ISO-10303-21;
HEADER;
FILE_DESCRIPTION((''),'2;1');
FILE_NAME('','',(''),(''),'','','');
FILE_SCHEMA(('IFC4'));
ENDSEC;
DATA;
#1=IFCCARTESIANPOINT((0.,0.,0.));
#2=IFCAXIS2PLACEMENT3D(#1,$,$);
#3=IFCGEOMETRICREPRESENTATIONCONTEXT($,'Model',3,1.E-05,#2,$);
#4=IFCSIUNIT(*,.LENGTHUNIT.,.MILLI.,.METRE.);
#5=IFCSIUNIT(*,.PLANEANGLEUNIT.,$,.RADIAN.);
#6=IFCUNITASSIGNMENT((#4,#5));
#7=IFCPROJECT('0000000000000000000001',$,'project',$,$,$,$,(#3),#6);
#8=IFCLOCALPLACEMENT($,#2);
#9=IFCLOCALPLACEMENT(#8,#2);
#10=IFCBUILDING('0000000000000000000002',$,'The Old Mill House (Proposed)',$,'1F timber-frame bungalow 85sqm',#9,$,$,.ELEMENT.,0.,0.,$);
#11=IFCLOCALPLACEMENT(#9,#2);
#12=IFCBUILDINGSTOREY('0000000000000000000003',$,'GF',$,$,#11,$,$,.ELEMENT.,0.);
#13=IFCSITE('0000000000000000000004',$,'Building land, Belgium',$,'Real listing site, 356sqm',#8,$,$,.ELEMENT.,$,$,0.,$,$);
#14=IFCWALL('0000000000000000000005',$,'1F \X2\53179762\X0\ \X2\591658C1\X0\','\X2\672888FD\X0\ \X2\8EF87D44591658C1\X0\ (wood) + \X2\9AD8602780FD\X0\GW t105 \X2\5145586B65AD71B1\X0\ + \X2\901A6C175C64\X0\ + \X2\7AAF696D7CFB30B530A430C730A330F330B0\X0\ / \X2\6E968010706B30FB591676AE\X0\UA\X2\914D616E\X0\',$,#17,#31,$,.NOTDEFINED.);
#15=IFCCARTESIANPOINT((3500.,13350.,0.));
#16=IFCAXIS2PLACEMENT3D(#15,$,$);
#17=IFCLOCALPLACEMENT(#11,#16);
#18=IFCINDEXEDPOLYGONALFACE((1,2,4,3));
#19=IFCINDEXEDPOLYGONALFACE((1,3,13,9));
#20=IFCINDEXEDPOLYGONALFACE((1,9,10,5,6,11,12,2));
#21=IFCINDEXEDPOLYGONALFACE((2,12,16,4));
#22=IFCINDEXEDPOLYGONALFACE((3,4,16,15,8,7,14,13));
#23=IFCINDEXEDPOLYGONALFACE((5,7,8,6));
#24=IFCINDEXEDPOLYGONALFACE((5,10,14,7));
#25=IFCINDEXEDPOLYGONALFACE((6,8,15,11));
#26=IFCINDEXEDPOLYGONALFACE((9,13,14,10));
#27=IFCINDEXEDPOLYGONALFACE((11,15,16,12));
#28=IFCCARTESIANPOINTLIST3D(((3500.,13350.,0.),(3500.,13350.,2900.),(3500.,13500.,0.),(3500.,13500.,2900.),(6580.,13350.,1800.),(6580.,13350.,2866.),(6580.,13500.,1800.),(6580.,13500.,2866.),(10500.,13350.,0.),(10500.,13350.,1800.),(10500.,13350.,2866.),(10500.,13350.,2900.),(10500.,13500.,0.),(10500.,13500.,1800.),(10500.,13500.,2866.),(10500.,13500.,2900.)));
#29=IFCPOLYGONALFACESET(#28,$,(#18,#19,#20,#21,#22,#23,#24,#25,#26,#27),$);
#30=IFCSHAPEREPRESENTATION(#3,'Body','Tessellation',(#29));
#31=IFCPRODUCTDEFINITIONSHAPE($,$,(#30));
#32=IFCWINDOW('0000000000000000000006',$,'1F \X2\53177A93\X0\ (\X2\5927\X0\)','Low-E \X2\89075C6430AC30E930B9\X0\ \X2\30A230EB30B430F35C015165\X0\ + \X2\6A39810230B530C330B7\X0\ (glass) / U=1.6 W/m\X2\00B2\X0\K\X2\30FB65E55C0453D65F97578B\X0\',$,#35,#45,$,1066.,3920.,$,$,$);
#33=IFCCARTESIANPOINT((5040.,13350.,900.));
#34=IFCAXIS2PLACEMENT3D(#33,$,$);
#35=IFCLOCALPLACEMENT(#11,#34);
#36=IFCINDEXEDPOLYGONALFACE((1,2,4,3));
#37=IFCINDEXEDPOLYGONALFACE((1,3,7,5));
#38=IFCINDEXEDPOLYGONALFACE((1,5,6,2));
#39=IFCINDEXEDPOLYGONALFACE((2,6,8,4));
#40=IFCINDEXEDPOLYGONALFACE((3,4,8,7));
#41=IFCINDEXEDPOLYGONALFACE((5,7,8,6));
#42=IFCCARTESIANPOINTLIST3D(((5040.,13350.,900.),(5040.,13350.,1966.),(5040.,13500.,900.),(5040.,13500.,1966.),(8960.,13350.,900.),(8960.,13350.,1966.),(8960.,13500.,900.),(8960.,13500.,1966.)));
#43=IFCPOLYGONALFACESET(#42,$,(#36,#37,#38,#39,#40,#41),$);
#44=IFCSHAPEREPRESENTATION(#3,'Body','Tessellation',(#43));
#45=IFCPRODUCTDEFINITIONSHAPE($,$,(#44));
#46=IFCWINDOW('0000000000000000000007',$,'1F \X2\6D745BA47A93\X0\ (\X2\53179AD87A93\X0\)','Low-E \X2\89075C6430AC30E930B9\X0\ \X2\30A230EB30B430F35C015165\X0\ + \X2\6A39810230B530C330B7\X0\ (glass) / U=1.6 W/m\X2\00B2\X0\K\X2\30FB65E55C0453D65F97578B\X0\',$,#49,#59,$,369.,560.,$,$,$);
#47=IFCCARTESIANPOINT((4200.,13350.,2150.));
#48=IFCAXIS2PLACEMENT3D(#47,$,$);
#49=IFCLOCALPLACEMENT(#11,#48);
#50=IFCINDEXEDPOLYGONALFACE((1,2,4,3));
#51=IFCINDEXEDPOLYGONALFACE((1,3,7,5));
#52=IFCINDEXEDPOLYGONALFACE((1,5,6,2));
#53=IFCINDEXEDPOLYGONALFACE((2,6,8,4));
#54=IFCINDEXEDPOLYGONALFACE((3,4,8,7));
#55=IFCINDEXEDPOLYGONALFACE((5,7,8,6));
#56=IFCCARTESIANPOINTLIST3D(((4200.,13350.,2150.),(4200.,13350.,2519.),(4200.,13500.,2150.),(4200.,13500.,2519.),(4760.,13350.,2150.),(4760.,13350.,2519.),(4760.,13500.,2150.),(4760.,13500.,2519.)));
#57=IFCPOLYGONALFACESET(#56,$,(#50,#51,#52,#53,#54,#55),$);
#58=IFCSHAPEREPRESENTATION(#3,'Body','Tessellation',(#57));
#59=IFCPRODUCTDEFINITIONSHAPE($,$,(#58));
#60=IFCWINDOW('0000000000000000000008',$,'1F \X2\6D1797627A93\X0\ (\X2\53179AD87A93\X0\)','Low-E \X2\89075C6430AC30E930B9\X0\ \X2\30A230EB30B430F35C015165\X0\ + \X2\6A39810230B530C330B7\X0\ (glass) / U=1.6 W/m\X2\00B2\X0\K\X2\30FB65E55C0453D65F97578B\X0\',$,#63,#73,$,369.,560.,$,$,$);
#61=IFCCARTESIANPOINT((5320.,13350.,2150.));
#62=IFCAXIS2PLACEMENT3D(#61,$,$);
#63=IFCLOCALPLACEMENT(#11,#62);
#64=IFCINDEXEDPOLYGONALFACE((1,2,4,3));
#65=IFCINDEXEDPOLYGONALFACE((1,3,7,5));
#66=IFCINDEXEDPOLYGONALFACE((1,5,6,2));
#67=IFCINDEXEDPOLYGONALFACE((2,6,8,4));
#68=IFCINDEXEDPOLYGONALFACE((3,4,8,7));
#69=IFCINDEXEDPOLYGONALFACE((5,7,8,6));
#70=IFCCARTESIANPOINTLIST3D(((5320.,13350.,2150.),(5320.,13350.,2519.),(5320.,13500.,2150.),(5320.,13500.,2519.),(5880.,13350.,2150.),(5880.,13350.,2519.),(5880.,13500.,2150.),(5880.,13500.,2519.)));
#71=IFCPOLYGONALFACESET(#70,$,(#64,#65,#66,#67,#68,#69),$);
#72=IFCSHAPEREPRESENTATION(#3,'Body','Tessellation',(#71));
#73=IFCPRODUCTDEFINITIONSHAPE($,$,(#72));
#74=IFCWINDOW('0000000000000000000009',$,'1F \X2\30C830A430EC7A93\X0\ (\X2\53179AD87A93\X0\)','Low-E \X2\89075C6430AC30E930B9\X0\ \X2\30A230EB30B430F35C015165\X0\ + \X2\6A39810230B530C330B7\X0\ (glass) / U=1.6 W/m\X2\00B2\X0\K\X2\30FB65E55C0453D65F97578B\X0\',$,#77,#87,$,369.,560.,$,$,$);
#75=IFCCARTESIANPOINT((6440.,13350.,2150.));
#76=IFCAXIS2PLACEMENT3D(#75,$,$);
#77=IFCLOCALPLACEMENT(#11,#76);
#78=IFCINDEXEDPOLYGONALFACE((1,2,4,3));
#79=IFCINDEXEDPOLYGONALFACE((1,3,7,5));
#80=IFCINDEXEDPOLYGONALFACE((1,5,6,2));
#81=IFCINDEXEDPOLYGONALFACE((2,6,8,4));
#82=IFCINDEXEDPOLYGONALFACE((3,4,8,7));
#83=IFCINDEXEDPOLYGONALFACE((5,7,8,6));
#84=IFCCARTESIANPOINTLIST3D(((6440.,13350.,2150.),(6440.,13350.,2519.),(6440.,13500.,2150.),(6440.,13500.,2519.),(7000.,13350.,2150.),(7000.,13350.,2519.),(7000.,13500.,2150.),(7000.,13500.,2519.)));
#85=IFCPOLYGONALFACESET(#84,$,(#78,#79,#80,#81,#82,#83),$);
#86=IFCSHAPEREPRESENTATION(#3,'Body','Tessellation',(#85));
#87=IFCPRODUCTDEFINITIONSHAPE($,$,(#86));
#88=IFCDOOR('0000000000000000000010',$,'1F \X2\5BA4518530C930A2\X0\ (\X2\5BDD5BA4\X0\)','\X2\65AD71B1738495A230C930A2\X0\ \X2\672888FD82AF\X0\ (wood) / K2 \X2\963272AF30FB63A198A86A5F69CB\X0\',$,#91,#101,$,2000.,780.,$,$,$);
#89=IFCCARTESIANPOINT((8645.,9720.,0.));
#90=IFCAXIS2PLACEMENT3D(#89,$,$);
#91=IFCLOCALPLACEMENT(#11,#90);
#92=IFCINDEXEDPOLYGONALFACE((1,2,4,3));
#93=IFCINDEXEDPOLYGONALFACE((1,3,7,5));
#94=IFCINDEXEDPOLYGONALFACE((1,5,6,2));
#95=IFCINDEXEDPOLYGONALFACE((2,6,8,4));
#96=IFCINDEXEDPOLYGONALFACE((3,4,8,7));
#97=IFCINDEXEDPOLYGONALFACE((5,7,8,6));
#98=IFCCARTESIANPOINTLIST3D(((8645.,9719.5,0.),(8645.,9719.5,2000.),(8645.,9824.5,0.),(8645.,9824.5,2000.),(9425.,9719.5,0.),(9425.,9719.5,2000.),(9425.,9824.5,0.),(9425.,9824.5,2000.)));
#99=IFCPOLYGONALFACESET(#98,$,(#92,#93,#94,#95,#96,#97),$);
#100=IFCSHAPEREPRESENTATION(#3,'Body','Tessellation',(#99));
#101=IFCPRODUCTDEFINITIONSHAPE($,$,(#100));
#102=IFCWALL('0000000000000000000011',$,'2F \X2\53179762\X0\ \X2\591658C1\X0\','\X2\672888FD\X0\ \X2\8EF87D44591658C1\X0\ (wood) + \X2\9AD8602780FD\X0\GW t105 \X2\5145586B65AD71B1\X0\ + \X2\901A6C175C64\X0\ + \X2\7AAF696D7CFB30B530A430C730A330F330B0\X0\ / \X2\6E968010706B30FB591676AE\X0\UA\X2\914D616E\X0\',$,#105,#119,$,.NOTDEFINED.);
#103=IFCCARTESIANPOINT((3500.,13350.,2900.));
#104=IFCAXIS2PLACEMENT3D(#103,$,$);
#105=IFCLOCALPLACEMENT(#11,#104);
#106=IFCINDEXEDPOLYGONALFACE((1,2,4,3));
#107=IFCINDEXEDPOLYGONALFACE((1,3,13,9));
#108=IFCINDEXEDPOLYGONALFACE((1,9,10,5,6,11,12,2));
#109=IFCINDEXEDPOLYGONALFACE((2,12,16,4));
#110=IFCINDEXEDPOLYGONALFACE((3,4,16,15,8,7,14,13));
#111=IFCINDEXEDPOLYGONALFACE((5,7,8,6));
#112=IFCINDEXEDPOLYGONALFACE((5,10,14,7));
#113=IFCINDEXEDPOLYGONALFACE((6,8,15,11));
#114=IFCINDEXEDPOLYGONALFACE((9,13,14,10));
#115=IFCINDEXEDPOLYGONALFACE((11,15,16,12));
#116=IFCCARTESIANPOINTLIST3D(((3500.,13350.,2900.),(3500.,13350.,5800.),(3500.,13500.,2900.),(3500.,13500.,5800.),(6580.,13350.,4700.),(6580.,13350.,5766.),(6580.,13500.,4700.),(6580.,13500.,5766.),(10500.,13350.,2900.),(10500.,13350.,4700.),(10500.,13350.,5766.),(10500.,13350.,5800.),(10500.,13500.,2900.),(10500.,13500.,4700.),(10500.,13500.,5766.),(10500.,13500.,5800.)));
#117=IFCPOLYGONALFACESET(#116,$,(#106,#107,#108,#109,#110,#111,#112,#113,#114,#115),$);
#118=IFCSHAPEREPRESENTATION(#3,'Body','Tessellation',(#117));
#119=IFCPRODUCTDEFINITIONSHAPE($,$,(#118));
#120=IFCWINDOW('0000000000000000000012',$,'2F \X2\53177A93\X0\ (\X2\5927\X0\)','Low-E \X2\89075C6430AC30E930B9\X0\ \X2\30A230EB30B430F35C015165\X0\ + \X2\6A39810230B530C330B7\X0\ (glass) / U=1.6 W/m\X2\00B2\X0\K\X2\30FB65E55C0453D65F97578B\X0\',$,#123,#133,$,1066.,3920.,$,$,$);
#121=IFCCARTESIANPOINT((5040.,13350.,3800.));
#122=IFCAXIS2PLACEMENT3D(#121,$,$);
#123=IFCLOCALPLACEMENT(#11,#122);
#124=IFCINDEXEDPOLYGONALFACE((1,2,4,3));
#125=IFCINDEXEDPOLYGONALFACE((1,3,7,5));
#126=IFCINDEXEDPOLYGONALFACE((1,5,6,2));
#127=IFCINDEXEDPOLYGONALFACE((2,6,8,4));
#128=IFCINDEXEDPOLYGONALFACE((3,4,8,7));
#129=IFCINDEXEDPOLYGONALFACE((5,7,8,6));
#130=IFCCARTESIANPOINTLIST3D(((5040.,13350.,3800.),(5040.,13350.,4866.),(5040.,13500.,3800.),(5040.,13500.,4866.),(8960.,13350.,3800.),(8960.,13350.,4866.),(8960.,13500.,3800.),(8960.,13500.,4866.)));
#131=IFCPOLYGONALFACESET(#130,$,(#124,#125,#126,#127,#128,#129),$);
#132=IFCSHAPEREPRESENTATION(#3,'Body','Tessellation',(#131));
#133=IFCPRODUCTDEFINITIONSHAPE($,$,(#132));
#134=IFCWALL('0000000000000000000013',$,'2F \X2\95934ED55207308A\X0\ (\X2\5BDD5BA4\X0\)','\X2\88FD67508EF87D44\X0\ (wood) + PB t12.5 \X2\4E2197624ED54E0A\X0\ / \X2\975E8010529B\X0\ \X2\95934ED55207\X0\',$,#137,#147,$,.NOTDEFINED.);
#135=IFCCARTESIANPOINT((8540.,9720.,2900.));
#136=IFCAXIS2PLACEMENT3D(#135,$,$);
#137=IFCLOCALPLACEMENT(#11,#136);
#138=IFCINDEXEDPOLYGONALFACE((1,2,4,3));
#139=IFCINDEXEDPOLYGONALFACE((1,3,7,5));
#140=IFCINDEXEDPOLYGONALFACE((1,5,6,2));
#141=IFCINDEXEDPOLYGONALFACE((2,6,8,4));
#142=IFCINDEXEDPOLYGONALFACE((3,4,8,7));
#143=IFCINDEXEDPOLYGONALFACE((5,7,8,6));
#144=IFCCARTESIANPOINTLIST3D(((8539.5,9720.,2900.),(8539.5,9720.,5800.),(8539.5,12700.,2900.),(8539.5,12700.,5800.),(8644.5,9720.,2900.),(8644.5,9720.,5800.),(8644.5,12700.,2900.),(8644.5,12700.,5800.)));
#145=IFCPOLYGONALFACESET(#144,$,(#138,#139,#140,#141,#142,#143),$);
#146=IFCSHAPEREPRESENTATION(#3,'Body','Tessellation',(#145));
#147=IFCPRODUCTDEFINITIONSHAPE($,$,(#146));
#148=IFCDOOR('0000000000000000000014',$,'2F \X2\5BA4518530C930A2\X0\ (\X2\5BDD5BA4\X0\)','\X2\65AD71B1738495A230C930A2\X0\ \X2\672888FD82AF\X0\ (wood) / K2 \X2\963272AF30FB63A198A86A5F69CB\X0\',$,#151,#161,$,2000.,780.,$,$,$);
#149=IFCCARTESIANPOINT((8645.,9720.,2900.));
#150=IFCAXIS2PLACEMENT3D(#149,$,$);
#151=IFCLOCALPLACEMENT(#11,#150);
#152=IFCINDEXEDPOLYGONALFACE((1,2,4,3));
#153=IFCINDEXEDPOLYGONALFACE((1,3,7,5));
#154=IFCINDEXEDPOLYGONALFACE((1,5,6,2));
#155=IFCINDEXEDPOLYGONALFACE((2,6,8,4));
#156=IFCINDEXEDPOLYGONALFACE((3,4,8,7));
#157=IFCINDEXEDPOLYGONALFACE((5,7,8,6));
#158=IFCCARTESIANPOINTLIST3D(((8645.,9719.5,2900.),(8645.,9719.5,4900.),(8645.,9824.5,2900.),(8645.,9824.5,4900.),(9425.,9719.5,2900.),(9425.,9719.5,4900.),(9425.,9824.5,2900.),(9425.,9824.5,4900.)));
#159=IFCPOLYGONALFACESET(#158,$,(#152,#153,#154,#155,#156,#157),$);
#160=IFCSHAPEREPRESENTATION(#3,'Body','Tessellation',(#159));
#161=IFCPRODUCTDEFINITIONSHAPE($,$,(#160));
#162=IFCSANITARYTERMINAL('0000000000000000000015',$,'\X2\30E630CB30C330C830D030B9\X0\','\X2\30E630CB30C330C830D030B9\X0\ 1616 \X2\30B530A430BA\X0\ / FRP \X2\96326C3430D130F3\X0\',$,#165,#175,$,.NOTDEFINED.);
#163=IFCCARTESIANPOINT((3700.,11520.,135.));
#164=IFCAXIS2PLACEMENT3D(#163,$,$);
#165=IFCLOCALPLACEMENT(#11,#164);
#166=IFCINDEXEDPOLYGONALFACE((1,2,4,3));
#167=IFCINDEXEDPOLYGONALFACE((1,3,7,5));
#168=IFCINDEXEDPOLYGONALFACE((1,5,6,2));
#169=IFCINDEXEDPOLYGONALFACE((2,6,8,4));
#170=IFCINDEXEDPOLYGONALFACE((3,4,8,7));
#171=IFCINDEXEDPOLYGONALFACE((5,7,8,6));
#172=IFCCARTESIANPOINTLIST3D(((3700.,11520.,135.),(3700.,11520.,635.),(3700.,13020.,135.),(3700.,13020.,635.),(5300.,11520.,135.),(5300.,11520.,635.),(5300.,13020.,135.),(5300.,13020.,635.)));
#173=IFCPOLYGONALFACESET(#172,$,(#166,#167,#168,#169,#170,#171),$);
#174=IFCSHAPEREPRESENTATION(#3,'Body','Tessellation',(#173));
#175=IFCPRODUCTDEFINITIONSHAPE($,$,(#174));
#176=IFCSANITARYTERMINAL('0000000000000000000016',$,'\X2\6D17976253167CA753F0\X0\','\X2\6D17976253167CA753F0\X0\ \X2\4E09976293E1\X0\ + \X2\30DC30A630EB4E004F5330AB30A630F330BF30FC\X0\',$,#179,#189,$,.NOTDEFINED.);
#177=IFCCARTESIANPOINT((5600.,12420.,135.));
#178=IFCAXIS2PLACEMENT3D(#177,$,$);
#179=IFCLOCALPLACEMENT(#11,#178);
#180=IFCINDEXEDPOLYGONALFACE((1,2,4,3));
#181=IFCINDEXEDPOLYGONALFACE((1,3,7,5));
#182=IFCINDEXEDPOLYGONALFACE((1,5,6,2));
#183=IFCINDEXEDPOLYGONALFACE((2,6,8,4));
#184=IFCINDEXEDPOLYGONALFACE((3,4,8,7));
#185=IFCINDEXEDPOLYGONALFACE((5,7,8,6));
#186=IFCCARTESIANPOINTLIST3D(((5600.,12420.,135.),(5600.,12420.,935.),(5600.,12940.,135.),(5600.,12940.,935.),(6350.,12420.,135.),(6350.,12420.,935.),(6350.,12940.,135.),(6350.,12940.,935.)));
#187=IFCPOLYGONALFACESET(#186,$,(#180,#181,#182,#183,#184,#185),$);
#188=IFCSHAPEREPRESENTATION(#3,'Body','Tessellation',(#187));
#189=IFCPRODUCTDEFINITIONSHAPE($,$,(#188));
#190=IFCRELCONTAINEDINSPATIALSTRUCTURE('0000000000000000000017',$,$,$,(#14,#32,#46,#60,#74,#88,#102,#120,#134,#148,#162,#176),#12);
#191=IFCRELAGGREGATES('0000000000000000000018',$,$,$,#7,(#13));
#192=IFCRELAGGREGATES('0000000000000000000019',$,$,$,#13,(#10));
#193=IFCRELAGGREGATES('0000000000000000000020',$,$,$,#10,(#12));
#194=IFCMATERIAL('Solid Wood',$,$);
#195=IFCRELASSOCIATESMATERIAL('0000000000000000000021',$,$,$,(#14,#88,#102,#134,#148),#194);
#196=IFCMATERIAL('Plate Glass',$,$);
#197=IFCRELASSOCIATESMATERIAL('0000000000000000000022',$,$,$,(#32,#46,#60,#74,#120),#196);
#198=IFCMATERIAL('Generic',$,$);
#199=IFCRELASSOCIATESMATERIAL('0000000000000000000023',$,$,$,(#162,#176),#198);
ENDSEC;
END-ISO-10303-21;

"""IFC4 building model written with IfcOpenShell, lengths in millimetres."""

from ifc_helpers import new_model, si_unit, frame, frame_2d, origin, place, context, project, spatial, rectangle, extrude, material, element, fill, save


model = new_model("IFC4")

# Units and contexts
model_context = context("Model", 3, precision=1e-05, world=origin())
ifc_project = project(units=[si_unit("LENGTHUNIT", "METRE", prefix="MILLI"), si_unit("PLANEANGLEUNIT", "RADIAN")], contexts=[model_context])

# Site, building, storey
site_placement = place(None, origin())
site = spatial("IfcSite", under=ifc_project, at=site_placement, Name="Building land, Belgium", ObjectType="Real listing site, 356sqm", CompositionType="ELEMENT", RefElevation=0.0)
building_placement = place(site_placement, origin())
building = spatial("IfcBuilding", under=site, at=building_placement, Name="The Old Mill House (Proposed)", ObjectType="1F timber-frame bungalow 85sqm", CompositionType="ELEMENT", ElevationOfRefHeight=0.0, ElevationOfTerrain=0.0)
storey_placement = place(building_placement, origin())
storey = spatial("IfcBuildingStorey", under=building, at=storey_placement, Name="GF", CompositionType="ELEMENT", Elevation=0.0)

# Wall, openings, windows
ifc_material_1 = material(Name="Solid Wood")
wall_1_placement = place(storey_placement, frame((3500.0, 13350.0, 0.0)))
wall_1 = element("IfcWall", 1, at=wall_1_placement, inside=storey, material=ifc_material_1, Name="1F 北面 外壁", Description="木製 軸組外壁 (wood) + 高性能GW t105 充填断熱 + 通気層 + 窯業系サイディング / 準耐火・外皮UA配慮", PredefinedType="NOTDEFINED", context=model_context, shape_type="SweptSolid", body=[
    extrude(rectangle(XDim=7000.0, YDim=150.0, at=frame_2d((3500.0, 75.0))), frame((3500.0, 13350.0, 0.0)), (0.0, 0.0, 1.0), 2900.0),
])
opening_1_placement = place(storey_placement, frame((5040.0, 13350.0, 900.0)))
opening_1 = element("IfcOpeningElement", 2, at=opening_1_placement, cuts=wall_1, PredefinedType="NOTDEFINED", context=model_context, shape_type="SweptSolid", body=[
    extrude(rectangle(XDim=3920.0, YDim=150.0, at=frame_2d((1960.0, 75.0))), frame((5040.0, 13350.0, 900.0)), (0.0, 0.0, 1.0), 1066.0),
])
opening_2_placement = place(storey_placement, frame((4200.0, 13350.0, 2150.0)))
opening_2 = element("IfcOpeningElement", 3, at=opening_2_placement, cuts=wall_1, PredefinedType="NOTDEFINED", context=model_context, shape_type="SweptSolid", body=[
    extrude(rectangle(XDim=560.0, YDim=150.0, at=frame_2d((280.0, 75.0))), frame((4200.0, 13350.0, 2150.0)), (0.0, 0.0, 1.0), 369.0),
])
opening_3_placement = place(storey_placement, frame((5320.0, 13350.0, 2150.0)))
opening_3 = element("IfcOpeningElement", 4, at=opening_3_placement, cuts=wall_1, PredefinedType="NOTDEFINED", context=model_context, shape_type="SweptSolid", body=[
    extrude(rectangle(XDim=560.0, YDim=150.0, at=frame_2d((280.0, 75.0))), frame((5320.0, 13350.0, 2150.0)), (0.0, 0.0, 1.0), 369.0),
])
opening_4_placement = place(storey_placement, frame((6440.0, 13350.0, 2150.0)))
opening_4 = element("IfcOpeningElement", 5, at=opening_4_placement, cuts=wall_1, PredefinedType="NOTDEFINED", context=model_context, shape_type="SweptSolid", body=[
    extrude(rectangle(XDim=560.0, YDim=150.0, at=frame_2d((280.0, 75.0))), frame((6440.0, 13350.0, 2150.0)), (0.0, 0.0, 1.0), 369.0),
])
ifc_material_2 = material(Name="Plate Glass")
window_1_placement = place(storey_placement, frame((5040.0, 13350.0, 900.0)))
window_1 = element("IfcWindow", 6, at=window_1_placement, inside=storey, material=ifc_material_2, Name="1F 北窓 (大)", Description="Low-E 複層ガラス アルゴン封入 + 樹脂サッシ (glass) / U=1.6 W/m²K・日射取得型", OverallHeight=1066.0, OverallWidth=3920.0, context=model_context, shape_type="SweptSolid", body=[
    extrude(rectangle(XDim=3920.0, YDim=150.0, at=frame_2d((1960.0, 75.0))), frame((5040.0, 13350.0, 900.0)), (0.0, 0.0, 1.0), 1066.0),
])
fill(opening_1, window_1)
window_2_placement = place(storey_placement, frame((4200.0, 13350.0, 2150.0)))
window_2 = element("IfcWindow", 7, at=window_2_placement, inside=storey, material=ifc_material_2, Name="1F 浴室窓 (北高窓)", Description="Low-E 複層ガラス アルゴン封入 + 樹脂サッシ (glass) / U=1.6 W/m²K・日射取得型", OverallHeight=369.0, OverallWidth=560.0, context=model_context, shape_type="SweptSolid", body=[
    extrude(rectangle(XDim=560.0, YDim=150.0, at=frame_2d((280.0, 75.0))), frame((4200.0, 13350.0, 2150.0)), (0.0, 0.0, 1.0), 369.0),
])
fill(opening_2, window_2)
window_3_placement = place(storey_placement, frame((5320.0, 13350.0, 2150.0)))
window_3 = element("IfcWindow", 8, at=window_3_placement, inside=storey, material=ifc_material_2, Name="1F 洗面窓 (北高窓)", Description="Low-E 複層ガラス アルゴン封入 + 樹脂サッシ (glass) / U=1.6 W/m²K・日射取得型", OverallHeight=369.0, OverallWidth=560.0, context=model_context, shape_type="SweptSolid", body=[
    extrude(rectangle(XDim=560.0, YDim=150.0, at=frame_2d((280.0, 75.0))), frame((5320.0, 13350.0, 2150.0)), (0.0, 0.0, 1.0), 369.0),
])
fill(opening_3, window_3)
window_4_placement = place(storey_placement, frame((6440.0, 13350.0, 2150.0)))
window_4 = element("IfcWindow", 9, at=window_4_placement, inside=storey, material=ifc_material_2, Name="1F トイレ窓 (北高窓)", Description="Low-E 複層ガラス アルゴン封入 + 樹脂サッシ (glass) / U=1.6 W/m²K・日射取得型", OverallHeight=369.0, OverallWidth=560.0, context=model_context, shape_type="SweptSolid", body=[
    extrude(rectangle(XDim=560.0, YDim=150.0, at=frame_2d((280.0, 75.0))), frame((6440.0, 13350.0, 2150.0)), (0.0, 0.0, 1.0), 369.0),
])
fill(opening_4, window_4)

# Door
door_1_placement = place(storey_placement, frame((8645.0, 9720.0, 0.0)))
element("IfcDoor", 10, at=door_1_placement, inside=storey, material=ifc_material_1, Name="1F 室内ドア (寝室)", Description="断熱玄関ドア 木製芯 (wood) / K2 防犯・採風機構", OverallHeight=2000.0, OverallWidth=780.0, context=model_context, shape_type="SweptSolid", body=[
    extrude(rectangle(XDim=780.0, YDim=105.0, at=frame_2d((390.0, 52.0))), frame((8645.0, 9720.0, 0.0)), (0.0, 0.0, 1.0), 2000.0),
])

# Wall, opening, window
wall_2_placement = place(storey_placement, frame((3500.0, 13350.0, 2900.0)))
wall_2 = element("IfcWall", 11, at=wall_2_placement, inside=storey, material=ifc_material_1, Name="2F 北面 外壁", Description="木製 軸組外壁 (wood) + 高性能GW t105 充填断熱 + 通気層 + 窯業系サイディング / 準耐火・外皮UA配慮", PredefinedType="NOTDEFINED", context=model_context, shape_type="SweptSolid", body=[
    extrude(rectangle(XDim=7000.0, YDim=150.0, at=frame_2d((3500.0, 75.0))), frame((3500.0, 13350.0, 2900.0)), (0.0, 0.0, 1.0), 2900.0),
])
opening_5_placement = place(storey_placement, frame((5040.0, 13350.0, 3800.0)))
opening_5 = element("IfcOpeningElement", 12, at=opening_5_placement, cuts=wall_2, PredefinedType="NOTDEFINED", context=model_context, shape_type="SweptSolid", body=[
    extrude(rectangle(XDim=3920.0, YDim=150.0, at=frame_2d((1960.0, 75.0))), frame((5040.0, 13350.0, 3800.0)), (0.0, 0.0, 1.0), 1066.0),
])
window_5_placement = place(storey_placement, frame((5040.0, 13350.0, 3800.0)))
window_5 = element("IfcWindow", 13, at=window_5_placement, inside=storey, material=ifc_material_2, Name="2F 北窓 (大)", Description="Low-E 複層ガラス アルゴン封入 + 樹脂サッシ (glass) / U=1.6 W/m²K・日射取得型", OverallHeight=1066.0, OverallWidth=3920.0, context=model_context, shape_type="SweptSolid", body=[
    extrude(rectangle(XDim=3920.0, YDim=150.0, at=frame_2d((1960.0, 75.0))), frame((5040.0, 13350.0, 3800.0)), (0.0, 0.0, 1.0), 1066.0),
])
fill(opening_5, window_5)

# Wall
wall_3_placement = place(storey_placement, frame((8540.0, 9720.0, 2900.0)))
element("IfcWall", 14, at=wall_3_placement, inside=storey, material=ifc_material_1, Name="2F 間仕切り (寝室)", Description="製材軸組 (wood) + PB t12.5 両面仕上 / 非耐力 間仕切", PredefinedType="NOTDEFINED", context=model_context, shape_type="SweptSolid", body=[
    extrude(rectangle(XDim=105.0, YDim=2980.0, at=frame_2d((52.0, 1490.0))), frame((8540.0, 9720.0, 2900.0)), (0.0, 0.0, 1.0), 2900.0),
])

# Door
door_2_placement = place(storey_placement, frame((8645.0, 9720.0, 2900.0)))
element("IfcDoor", 15, at=door_2_placement, inside=storey, material=ifc_material_1, Name="2F 室内ドア (寝室)", Description="断熱玄関ドア 木製芯 (wood) / K2 防犯・採風機構", OverallHeight=2000.0, OverallWidth=780.0, context=model_context, shape_type="SweptSolid", body=[
    extrude(rectangle(XDim=780.0, YDim=105.0, at=frame_2d((390.0, 52.0))), frame((8645.0, 9720.0, 2900.0)), (0.0, 0.0, 1.0), 2000.0),
])

# Sanitary terminals
ifc_material_3 = material(Name="Generic")
sanitary_terminal_1_placement = place(storey_placement, frame((3700.0, 11520.0, 135.0)))
element("IfcSanitaryTerminal", 16, at=sanitary_terminal_1_placement, inside=storey, material=ifc_material_3, Name="ユニットバス", Description="ユニットバス 1616 サイズ / FRP 防水パン", PredefinedType="NOTDEFINED", context=model_context, shape_type="SweptSolid", body=[
    extrude(rectangle(XDim=1600.0, YDim=1500.0, at=frame_2d((800.0, 750.0))), frame((3700.0, 11520.0, 135.0)), (0.0, 0.0, 1.0), 500.0),
])
sanitary_terminal_2_placement = place(storey_placement, frame((5600.0, 12420.0, 135.0)))
element("IfcSanitaryTerminal", 17, at=sanitary_terminal_2_placement, inside=storey, material=ifc_material_3, Name="洗面化粧台", Description="洗面化粧台 三面鏡 + ボウル一体カウンター", PredefinedType="NOTDEFINED", context=model_context, shape_type="SweptSolid", body=[
    extrude(rectangle(XDim=750.0, YDim=520.0, at=frame_2d((375.0, 260.0))), frame((5600.0, 12420.0, 135.0)), (0.0, 0.0, 1.0), 800.0),
])

save(model, "model.ifc")
